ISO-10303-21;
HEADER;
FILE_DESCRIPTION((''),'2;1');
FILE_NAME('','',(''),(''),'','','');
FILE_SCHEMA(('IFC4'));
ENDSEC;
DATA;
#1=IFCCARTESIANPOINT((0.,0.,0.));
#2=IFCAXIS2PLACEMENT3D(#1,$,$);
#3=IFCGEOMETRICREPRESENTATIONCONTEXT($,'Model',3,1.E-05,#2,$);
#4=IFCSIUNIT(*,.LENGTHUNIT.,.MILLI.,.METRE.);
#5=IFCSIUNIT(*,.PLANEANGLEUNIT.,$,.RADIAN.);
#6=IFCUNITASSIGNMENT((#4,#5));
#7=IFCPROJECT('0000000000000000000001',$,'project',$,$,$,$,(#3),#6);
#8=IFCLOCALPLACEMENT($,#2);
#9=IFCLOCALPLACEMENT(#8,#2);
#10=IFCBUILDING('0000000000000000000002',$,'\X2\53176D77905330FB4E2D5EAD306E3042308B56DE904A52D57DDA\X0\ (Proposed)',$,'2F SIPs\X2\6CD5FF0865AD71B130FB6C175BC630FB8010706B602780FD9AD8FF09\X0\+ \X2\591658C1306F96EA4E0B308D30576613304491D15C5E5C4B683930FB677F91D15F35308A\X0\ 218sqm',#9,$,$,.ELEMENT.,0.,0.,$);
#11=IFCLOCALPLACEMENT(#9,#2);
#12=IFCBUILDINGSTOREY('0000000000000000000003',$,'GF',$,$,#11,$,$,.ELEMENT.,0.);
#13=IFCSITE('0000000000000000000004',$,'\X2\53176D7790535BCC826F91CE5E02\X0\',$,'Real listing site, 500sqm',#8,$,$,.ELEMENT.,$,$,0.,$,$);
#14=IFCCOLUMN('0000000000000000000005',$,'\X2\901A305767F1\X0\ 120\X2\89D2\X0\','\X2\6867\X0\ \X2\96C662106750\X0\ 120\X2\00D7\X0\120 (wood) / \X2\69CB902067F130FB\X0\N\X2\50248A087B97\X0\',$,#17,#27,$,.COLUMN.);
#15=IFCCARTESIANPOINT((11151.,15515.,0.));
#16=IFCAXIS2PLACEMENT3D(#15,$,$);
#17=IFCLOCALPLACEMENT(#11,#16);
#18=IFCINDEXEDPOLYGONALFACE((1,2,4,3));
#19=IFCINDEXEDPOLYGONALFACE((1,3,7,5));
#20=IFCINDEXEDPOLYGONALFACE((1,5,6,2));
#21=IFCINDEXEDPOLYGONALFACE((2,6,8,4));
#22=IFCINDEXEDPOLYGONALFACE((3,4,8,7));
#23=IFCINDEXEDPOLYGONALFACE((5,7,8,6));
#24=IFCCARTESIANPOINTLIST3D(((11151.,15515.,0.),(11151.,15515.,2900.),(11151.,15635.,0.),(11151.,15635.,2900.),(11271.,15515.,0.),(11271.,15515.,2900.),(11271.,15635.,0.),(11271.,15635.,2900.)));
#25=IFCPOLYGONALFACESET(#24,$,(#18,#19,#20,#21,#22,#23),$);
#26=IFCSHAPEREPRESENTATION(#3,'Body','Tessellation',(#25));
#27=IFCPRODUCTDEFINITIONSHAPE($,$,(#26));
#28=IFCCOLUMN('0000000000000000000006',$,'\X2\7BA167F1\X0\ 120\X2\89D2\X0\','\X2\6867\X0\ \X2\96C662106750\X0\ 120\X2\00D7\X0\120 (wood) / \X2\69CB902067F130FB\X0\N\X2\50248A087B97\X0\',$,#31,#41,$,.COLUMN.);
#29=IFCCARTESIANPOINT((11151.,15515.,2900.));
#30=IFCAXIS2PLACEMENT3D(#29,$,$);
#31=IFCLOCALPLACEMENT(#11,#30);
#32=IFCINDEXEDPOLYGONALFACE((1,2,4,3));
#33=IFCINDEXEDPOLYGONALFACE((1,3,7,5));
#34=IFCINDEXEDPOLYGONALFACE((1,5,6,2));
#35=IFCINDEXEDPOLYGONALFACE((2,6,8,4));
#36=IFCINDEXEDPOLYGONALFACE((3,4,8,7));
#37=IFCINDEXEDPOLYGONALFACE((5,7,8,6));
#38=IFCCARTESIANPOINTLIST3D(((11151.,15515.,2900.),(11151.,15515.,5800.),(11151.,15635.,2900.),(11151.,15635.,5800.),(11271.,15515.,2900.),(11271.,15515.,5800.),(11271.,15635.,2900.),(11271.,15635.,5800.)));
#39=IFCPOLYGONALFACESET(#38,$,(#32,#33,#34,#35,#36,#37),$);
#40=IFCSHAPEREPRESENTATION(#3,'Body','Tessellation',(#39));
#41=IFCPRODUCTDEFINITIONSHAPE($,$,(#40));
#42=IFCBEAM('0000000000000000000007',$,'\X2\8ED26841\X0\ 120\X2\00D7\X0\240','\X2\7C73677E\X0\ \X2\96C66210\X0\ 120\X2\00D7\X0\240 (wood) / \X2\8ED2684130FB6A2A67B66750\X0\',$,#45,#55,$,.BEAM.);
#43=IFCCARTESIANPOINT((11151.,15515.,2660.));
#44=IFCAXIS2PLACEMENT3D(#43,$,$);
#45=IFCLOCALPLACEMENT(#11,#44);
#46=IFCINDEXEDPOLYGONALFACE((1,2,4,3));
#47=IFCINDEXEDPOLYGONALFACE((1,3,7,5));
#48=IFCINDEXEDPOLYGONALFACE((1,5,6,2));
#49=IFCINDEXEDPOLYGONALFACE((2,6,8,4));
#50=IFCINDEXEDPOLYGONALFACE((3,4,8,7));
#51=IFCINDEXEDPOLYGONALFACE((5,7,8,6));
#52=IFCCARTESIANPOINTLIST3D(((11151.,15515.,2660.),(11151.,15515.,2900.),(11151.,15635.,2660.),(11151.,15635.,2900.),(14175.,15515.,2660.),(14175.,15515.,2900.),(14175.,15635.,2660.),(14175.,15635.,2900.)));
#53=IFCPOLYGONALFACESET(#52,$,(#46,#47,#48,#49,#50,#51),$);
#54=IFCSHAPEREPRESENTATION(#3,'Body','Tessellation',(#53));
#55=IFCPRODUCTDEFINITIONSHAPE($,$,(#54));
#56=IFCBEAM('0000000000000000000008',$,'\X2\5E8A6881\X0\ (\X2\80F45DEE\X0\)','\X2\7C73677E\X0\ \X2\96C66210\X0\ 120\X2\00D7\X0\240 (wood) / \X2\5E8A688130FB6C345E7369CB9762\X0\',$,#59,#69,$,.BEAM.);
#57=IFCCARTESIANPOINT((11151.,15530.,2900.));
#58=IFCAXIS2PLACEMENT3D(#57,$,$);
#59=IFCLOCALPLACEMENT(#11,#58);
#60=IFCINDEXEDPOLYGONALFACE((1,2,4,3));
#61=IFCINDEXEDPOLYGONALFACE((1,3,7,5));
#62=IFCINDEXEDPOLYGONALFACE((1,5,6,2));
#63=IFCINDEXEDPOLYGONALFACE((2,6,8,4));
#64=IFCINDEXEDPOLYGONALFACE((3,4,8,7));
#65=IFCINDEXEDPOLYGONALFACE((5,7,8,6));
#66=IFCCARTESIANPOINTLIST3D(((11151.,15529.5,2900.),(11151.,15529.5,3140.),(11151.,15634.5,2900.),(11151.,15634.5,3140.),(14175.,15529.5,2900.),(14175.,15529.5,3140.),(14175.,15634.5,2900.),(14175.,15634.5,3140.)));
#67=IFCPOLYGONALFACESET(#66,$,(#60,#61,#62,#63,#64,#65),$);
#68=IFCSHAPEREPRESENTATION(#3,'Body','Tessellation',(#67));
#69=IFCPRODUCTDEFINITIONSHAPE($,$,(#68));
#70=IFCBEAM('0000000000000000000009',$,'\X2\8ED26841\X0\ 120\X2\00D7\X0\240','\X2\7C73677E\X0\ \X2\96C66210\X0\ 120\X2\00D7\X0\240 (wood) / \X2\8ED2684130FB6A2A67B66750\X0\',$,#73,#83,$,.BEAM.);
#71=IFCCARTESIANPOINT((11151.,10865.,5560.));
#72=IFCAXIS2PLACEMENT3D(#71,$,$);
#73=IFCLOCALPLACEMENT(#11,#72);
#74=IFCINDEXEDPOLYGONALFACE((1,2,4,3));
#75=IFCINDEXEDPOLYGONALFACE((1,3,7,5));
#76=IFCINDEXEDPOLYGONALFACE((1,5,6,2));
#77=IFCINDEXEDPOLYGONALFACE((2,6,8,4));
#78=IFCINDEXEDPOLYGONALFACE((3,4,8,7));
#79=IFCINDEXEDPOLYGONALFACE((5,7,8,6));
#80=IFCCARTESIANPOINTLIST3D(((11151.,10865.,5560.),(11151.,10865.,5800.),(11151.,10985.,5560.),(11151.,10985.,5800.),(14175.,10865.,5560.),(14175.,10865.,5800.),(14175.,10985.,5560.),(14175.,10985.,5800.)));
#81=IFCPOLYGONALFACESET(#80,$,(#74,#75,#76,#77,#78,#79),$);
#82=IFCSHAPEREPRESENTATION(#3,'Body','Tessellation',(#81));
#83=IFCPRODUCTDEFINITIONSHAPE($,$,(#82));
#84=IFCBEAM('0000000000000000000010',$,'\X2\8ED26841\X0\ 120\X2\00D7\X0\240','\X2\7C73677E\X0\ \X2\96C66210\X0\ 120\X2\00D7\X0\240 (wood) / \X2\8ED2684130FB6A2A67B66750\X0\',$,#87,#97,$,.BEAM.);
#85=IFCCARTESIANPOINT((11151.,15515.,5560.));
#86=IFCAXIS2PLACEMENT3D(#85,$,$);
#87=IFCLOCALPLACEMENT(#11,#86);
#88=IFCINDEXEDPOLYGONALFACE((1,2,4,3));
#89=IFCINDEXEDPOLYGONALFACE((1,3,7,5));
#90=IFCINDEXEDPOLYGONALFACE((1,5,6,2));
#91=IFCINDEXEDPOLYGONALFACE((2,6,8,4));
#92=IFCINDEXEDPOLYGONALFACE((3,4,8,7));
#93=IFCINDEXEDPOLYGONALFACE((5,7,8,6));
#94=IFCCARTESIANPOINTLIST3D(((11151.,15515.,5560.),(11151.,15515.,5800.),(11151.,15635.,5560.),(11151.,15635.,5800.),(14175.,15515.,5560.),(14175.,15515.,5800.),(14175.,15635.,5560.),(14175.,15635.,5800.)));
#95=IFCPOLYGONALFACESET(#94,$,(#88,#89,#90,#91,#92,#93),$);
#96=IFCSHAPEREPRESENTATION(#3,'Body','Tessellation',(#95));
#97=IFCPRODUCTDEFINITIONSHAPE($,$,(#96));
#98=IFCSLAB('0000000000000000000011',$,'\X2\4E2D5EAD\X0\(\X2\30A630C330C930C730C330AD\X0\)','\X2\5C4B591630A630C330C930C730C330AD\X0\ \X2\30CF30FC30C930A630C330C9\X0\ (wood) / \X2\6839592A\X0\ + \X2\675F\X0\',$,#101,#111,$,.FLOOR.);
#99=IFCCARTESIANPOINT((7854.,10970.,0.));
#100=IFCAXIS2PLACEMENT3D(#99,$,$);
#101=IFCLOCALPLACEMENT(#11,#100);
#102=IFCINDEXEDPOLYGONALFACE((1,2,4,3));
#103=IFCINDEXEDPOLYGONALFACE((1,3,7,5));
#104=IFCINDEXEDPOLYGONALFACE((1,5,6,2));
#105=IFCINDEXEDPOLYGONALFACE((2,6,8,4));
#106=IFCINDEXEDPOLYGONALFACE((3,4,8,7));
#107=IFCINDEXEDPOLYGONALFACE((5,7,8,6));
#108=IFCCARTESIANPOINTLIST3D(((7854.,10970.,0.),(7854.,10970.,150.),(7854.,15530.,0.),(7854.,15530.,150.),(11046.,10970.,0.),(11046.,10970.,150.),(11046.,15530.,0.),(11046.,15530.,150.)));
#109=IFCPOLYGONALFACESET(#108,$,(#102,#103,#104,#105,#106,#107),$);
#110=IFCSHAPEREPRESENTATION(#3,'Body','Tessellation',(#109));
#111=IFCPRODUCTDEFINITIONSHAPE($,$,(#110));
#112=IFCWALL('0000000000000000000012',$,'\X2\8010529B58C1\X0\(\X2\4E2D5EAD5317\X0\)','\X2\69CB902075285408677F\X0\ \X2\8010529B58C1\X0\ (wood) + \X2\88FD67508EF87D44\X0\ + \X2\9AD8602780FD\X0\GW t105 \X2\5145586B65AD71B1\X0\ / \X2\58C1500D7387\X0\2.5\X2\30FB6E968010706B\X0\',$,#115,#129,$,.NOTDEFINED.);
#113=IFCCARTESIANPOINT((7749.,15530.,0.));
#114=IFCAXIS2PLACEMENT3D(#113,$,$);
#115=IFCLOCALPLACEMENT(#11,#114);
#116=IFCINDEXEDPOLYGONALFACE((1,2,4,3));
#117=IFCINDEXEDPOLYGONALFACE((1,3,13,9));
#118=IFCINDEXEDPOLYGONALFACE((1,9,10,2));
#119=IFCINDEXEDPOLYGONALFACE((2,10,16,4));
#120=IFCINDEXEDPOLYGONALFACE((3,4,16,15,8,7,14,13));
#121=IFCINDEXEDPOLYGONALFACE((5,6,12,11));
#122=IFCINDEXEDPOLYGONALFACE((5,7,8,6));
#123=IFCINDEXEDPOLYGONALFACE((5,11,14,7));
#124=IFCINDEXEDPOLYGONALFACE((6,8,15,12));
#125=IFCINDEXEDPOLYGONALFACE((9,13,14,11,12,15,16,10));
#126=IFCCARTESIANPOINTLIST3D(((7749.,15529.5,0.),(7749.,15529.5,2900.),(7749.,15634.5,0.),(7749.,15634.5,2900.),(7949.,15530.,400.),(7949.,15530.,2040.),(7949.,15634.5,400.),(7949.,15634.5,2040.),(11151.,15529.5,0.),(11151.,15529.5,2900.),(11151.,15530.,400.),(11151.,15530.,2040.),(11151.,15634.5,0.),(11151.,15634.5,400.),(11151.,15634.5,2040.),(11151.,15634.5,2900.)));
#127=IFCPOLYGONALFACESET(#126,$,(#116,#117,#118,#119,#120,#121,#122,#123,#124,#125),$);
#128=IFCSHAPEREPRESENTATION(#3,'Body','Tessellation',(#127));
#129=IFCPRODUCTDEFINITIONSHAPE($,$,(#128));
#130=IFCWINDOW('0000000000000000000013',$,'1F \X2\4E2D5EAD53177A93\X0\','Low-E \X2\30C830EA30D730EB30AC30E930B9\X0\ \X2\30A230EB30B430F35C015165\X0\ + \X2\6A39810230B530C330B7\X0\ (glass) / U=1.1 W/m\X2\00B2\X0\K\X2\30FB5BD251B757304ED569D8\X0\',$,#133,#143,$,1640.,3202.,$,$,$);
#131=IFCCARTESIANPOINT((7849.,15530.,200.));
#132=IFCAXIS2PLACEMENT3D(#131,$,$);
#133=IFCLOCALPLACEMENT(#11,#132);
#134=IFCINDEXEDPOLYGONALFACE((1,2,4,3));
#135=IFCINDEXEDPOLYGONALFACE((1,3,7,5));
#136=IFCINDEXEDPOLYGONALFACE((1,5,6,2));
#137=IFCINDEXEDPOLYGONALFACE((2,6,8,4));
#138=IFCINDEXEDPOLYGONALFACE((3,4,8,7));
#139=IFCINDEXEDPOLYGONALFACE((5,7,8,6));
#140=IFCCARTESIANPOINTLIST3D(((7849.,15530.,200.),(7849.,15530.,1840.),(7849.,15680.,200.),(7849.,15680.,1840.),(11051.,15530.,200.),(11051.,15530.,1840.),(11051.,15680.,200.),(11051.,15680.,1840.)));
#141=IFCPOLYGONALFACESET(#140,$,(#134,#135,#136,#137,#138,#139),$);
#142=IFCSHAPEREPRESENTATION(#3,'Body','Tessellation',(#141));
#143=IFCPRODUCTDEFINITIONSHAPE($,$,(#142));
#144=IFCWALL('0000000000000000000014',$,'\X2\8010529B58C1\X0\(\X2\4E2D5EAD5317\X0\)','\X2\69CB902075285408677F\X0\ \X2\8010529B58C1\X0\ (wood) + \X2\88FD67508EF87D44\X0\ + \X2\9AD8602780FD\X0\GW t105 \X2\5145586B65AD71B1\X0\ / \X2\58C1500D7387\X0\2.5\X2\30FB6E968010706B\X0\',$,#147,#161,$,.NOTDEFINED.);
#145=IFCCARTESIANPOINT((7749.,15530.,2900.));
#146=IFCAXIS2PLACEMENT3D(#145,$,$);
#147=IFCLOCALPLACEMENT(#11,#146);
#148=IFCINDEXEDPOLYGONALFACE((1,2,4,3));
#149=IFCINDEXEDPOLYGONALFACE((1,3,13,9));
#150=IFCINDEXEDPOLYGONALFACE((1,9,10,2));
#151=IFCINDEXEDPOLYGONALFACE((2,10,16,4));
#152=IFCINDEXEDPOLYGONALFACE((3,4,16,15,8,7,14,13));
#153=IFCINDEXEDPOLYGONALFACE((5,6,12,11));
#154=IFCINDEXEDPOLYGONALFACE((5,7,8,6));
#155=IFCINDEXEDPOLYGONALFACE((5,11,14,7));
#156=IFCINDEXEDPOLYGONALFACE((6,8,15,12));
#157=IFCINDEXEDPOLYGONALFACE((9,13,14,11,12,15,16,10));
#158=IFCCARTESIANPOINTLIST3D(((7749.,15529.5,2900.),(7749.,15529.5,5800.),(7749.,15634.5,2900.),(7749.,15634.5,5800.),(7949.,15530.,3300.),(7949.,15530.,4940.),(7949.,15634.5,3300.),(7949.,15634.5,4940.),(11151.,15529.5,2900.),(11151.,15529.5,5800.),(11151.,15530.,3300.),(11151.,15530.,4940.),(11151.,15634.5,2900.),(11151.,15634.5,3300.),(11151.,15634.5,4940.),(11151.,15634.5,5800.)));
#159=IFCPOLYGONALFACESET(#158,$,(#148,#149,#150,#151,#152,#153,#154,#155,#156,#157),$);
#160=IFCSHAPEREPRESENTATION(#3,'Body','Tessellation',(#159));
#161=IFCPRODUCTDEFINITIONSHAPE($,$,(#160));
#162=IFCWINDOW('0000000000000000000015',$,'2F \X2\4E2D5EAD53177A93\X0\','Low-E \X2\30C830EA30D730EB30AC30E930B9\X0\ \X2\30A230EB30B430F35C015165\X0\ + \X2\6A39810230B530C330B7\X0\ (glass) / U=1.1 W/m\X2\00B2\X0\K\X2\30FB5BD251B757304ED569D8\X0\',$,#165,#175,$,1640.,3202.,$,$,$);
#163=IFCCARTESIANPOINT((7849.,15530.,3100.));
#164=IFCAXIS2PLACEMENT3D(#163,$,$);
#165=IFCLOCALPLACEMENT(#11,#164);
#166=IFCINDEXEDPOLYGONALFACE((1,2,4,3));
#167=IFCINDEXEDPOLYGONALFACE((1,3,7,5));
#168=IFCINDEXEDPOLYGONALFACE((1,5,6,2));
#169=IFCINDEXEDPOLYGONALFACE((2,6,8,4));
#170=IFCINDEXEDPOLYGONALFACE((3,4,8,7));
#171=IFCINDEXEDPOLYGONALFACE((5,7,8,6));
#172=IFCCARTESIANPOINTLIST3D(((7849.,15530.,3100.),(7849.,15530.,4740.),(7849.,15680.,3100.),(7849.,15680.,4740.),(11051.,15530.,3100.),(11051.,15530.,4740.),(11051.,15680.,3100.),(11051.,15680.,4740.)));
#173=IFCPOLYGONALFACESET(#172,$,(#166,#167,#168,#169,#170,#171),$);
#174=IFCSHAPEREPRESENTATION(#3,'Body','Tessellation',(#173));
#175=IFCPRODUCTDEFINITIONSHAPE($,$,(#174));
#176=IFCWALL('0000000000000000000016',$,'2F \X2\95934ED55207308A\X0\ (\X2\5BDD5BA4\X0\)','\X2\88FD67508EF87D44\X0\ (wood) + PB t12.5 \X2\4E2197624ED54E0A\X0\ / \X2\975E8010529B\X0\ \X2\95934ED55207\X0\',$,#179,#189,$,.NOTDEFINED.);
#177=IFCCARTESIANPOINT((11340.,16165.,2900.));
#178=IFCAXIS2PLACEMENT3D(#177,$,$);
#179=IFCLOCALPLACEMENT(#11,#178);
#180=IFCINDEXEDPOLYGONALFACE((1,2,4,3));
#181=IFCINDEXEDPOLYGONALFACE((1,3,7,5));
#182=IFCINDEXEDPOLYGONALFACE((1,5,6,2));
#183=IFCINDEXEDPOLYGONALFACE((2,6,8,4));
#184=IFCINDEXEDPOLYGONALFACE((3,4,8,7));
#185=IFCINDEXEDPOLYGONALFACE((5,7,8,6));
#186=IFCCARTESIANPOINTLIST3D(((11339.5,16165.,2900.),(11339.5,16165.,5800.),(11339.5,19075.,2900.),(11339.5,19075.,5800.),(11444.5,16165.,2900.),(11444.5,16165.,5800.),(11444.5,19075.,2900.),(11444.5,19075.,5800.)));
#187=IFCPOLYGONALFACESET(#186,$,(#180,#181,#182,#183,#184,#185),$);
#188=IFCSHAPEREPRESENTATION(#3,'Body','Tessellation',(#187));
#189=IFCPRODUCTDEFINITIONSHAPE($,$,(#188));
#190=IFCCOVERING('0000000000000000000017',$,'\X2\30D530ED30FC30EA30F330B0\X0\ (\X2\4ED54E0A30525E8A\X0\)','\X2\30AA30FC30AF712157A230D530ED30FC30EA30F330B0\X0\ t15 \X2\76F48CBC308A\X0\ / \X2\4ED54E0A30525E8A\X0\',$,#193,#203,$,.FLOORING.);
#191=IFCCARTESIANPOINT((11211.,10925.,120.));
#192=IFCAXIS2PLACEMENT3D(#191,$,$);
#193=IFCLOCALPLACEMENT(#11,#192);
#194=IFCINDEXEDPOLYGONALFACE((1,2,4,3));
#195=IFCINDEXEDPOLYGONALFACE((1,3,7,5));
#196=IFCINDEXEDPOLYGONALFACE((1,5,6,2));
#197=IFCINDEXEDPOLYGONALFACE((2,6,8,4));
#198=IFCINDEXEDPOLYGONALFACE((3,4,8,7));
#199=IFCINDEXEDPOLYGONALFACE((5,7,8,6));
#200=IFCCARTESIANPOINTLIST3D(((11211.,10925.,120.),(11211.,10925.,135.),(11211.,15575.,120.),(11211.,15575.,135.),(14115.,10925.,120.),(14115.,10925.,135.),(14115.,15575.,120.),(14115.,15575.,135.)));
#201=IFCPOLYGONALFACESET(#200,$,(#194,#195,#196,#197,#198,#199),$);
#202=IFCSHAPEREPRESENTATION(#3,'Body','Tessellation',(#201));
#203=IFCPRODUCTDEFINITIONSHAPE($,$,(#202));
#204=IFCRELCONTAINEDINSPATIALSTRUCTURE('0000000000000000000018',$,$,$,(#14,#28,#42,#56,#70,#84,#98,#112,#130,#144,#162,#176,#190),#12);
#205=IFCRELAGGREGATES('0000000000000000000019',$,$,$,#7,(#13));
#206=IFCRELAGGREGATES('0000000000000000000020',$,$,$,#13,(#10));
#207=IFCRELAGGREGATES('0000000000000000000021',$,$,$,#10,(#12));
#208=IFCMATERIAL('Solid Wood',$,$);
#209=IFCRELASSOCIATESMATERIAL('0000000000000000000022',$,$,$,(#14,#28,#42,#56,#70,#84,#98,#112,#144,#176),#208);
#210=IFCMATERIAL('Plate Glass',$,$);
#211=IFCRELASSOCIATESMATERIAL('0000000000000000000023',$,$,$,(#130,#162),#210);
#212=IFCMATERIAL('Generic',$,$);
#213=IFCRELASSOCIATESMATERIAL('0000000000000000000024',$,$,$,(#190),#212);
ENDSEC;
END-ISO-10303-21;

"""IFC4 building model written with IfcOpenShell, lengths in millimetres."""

from ifc_helpers import new_model, si_unit, frame, frame_2d, origin, place, context, project, spatial, rectangle, extrude, material, element, fill, save


model = new_model("IFC4")

# Units and contexts
model_context = context("Model", 3, precision=1e-05, world=origin())
ifc_project = project(units=[si_unit("LENGTHUNIT", "METRE", prefix="MILLI"), si_unit("PLANEANGLEUNIT", "RADIAN")], contexts=[model_context])

# Site, building, storey
site_placement = place(None, origin())
site = spatial("IfcSite", under=ifc_project, at=site_placement, Name="北海道富良野市", ObjectType="Real listing site, 500sqm", CompositionType="ELEMENT", RefElevation=0.0)
building_placement = place(site_placement, origin())
building = spatial("IfcBuilding", under=site, at=building_placement, Name="北海道・中庭のある回遊動線 (Proposed)", ObjectType="2F SIPs法（断熱・気密・耐火性能高）+ 外壁は雪下ろし易い金属屋根・板金張り 218sqm", CompositionType="ELEMENT", ElevationOfRefHeight=0.0, ElevationOfTerrain=0.0)
storey_placement = place(building_placement, origin())
storey = spatial("IfcBuildingStorey", under=building, at=storey_placement, Name="GF", CompositionType="ELEMENT", Elevation=0.0)

# Columns
ifc_material_1 = material(Name="Solid Wood")
column_1_placement = place(storey_placement, frame((11151.0, 15515.0, 0.0)))
element("IfcColumn", 1, at=column_1_placement, inside=storey, material=ifc_material_1, Name="通し柱 120角", Description="桧 集成材 120×120 (wood) / 構造柱・N値計算", PredefinedType="COLUMN", context=model_context, shape_type="SweptSolid", body=[
    extrude(rectangle(XDim=120.0, YDim=120.0, at=frame_2d((60.0, 60.0))), frame((11151.0, 15515.0, 0.0)), (0.0, 0.0, 1.0), 2900.0),
])
column_2_placement = place(storey_placement, frame((11151.0, 15515.0, 2900.0)))
element("IfcColumn", 2, at=column_2_placement, inside=storey, material=ifc_material_1, Name="管柱 120角", Description="桧 集成材 120×120 (wood) / 構造柱・N値計算", PredefinedType="COLUMN", context=model_context, shape_type="SweptSolid", body=[
    extrude(rectangle(XDim=120.0, YDim=120.0, at=frame_2d((60.0, 60.0))), frame((11151.0, 15515.0, 2900.0)), (0.0, 0.0, 1.0), 2900.0),
])

# Beams
beam_1_placement = place(storey_placement, frame((11151.0, 15515.0, 2660.0)))
element("IfcBeam", 3, at=beam_1_placement, inside=storey, material=ifc_material_1, Name="軒桁 120×240", Description="米松 集成 120×240 (wood) / 軒桁・横架材", PredefinedType="BEAM", context=model_context, shape_type="SweptSolid", body=[
    extrude(rectangle(XDim=3024.0, YDim=120.0, at=frame_2d((1512.0, 60.0))), frame((11151.0, 15515.0, 2660.0)), (0.0, 0.0, 1.0), 240.0),
])
beam_2_placement = place(storey_placement, frame((11151.0, 15530.0, 2900.0)))
element("IfcBeam", 4, at=beam_2_placement, inside=storey, material=ifc_material_1, Name="床梁 (胴差)", Description="米松 集成 120×240 (wood) / 床梁・水平構面", PredefinedType="BEAM", context=model_context, shape_type="SweptSolid", body=[
    extrude(rectangle(XDim=3024.0, YDim=105.0, at=frame_2d((1512.0, 52.0))), frame((11151.0, 15530.0, 2900.0)), (0.0, 0.0, 1.0), 240.0),
])
beam_3_placement = place(storey_placement, frame((11151.0, 10865.0, 5560.0)))
element("IfcBeam", 5, at=beam_3_placement, inside=storey, material=ifc_material_1, Name="軒桁 120×240", Description="米松 集成 120×240 (wood) / 軒桁・横架材", PredefinedType="BEAM", context=model_context, shape_type="SweptSolid", body=[
    extrude(rectangle(XDim=3024.0, YDim=120.0, at=frame_2d((1512.0, 60.0))), frame((11151.0, 10865.0, 5560.0)), (0.0, 0.0, 1.0), 240.0),
])
beam_4_placement = place(storey_placement, frame((11151.0, 15515.0, 5560.0)))
element("IfcBeam", 6, at=beam_4_placement, inside=storey, material=ifc_material_1, Name="軒桁 120×240", Description="米松 集成 120×240 (wood) / 軒桁・横架材", PredefinedType="BEAM", context=model_context, shape_type="SweptSolid", body=[
    extrude(rectangle(XDim=3024.0, YDim=120.0, at=frame_2d((1512.0, 60.0))), frame((11151.0, 15515.0, 5560.0)), (0.0, 0.0, 1.0), 240.0),
])

# Slab
slab_placement = place(storey_placement, frame((7854.0, 10970.0, 0.0)))
element("IfcSlab", 7, at=slab_placement, inside=storey, material=ifc_material_1, Name="中庭(ウッドデッキ)", Description="屋外ウッドデッキ ハードウッド (wood) / 根太 + 束", PredefinedType="FLOOR", context=model_context, shape_type="SweptSolid", body=[
    extrude(rectangle(XDim=3192.0, YDim=4560.0, at=frame_2d((1596.0, 2280.0))), frame((7854.0, 10970.0, 0.0)), (0.0, 0.0, 1.0), 150.0),
])

# Wall, opening, window
wall_1_placement = place(storey_placement, frame((7749.0, 15530.0, 0.0)))
wall_1 = element("IfcWall", 8, at=wall_1_placement, inside=storey, material=ifc_material_1, Name="耐力壁(中庭北)", Description="構造用合板 耐力壁 (wood) + 製材軸組 + 高性能GW t105 充填断熱 / 壁倍率2.5・準耐火", PredefinedType="NOTDEFINED", context=model_context, shape_type="SweptSolid", body=[
    extrude(rectangle(XDim=3402.0, YDim=105.0, at=frame_2d((1701.0, 52.0))), frame((7749.0, 15530.0, 0.0)), (0.0, 0.0, 1.0), 2900.0),
])
opening_1_placement = place(storey_placement, frame((7849.0, 15530.0, 200.0)))
opening_1 = element("IfcOpeningElement", 9, at=opening_1_placement, cuts=wall_1, PredefinedType="NOTDEFINED", context=model_context, shape_type="SweptSolid", body=[
    extrude(rectangle(XDim=3202.0, YDim=150.0, at=frame_2d((1601.0, 75.0))), frame((7849.0, 15530.0, 200.0)), (0.0, 0.0, 1.0), 1640.0),
])
ifc_material_2 = material(Name="Plate Glass")
window_1_placement = place(storey_placement, frame((7849.0, 15530.0, 200.0)))
window_1 = element("IfcWindow", 10, at=window_1_placement, inside=storey, material=ifc_material_2, Name="1F 中庭北窓", Description="Low-E トリプルガラス アルゴン封入 + 樹脂サッシ (glass) / U=1.1 W/m²K・寒冷地仕様", OverallHeight=1640.0, OverallWidth=3202.0, context=model_context, shape_type="SweptSolid", body=[
    extrude(rectangle(XDim=3202.0, YDim=150.0, at=frame_2d((1601.0, 75.0))), frame((7849.0, 15530.0, 200.0)), (0.0, 0.0, 1.0), 1640.0),
])
fill(opening_1, window_1)

# Wall, opening, window
wall_2_placement = place(storey_placement, frame((7749.0, 15530.0, 2900.0)))
wall_2 = element("IfcWall", 11, at=wall_2_placement, inside=storey, material=ifc_material_1, Name="耐力壁(中庭北)", Description="構造用合板 耐力壁 (wood) + 製材軸組 + 高性能GW t105 充填断熱 / 壁倍率2.5・準耐火", PredefinedType="NOTDEFINED", context=model_context, shape_type="SweptSolid", body=[
    extrude(rectangle(XDim=3402.0, YDim=105.0, at=frame_2d((1701.0, 52.0))), frame((7749.0, 15530.0, 2900.0)), (0.0, 0.0, 1.0), 2900.0),
])
opening_2_placement = place(storey_placement, frame((7849.0, 15530.0, 3100.0)))
opening_2 = element("IfcOpeningElement", 12, at=opening_2_placement, cuts=wall_2, PredefinedType="NOTDEFINED", context=model_context, shape_type="SweptSolid", body=[
    extrude(rectangle(XDim=3202.0, YDim=150.0, at=frame_2d((1601.0, 75.0))), frame((7849.0, 15530.0, 3100.0)), (0.0, 0.0, 1.0), 1640.0),
])
window_2_placement = place(storey_placement, frame((7849.0, 15530.0, 3100.0)))
window_2 = element("IfcWindow", 13, at=window_2_placement, inside=storey, material=ifc_material_2, Name="2F 中庭北窓", Description="Low-E トリプルガラス アルゴン封入 + 樹脂サッシ (glass) / U=1.1 W/m²K・寒冷地仕様", OverallHeight=1640.0, OverallWidth=3202.0, context=model_context, shape_type="SweptSolid", body=[
    extrude(rectangle(XDim=3202.0, YDim=150.0, at=frame_2d((1601.0, 75.0))), frame((7849.0, 15530.0, 3100.0)), (0.0, 0.0, 1.0), 1640.0),
])
fill(opening_2, window_2)

# Wall
wall_3_placement = place(storey_placement, frame((11340.0, 16165.0, 2900.0)))
element("IfcWall", 14, at=wall_3_placement, inside=storey, material=ifc_material_1, Name="2F 間仕切り (寝室)", Description="製材軸組 (wood) + PB t12.5 両面仕上 / 非耐力 間仕切", PredefinedType="NOTDEFINED", context=model_context, shape_type="SweptSolid", body=[
    extrude(rectangle(XDim=105.0, YDim=2910.0, at=frame_2d((52.0, 1455.0))), frame((11340.0, 16165.0, 2900.0)), (0.0, 0.0, 1.0), 2900.0),
])

# Covering
ifc_material_3 = material(Name="Generic")
covering_1_placement = place(storey_placement, frame((11211.0, 10925.0, 120.0)))
element("IfcCovering", 15, at=covering_1_placement, inside=storey, material=ifc_material_3, Name="フローリング (仕上げ床)", Description="オーク無垢フローリング t15 直貼り / 仕上げ床", PredefinedType="FLOORING", context=model_context, shape_type="SweptSolid", body=[
    extrude(rectangle(XDim=2904.0, YDim=4650.0, at=frame_2d((1452.0, 2325.0))), frame((11211.0, 10925.0, 120.0)), (0.0, 0.0, 1.0), 15.0),
])

save(model, "model.ifc")
